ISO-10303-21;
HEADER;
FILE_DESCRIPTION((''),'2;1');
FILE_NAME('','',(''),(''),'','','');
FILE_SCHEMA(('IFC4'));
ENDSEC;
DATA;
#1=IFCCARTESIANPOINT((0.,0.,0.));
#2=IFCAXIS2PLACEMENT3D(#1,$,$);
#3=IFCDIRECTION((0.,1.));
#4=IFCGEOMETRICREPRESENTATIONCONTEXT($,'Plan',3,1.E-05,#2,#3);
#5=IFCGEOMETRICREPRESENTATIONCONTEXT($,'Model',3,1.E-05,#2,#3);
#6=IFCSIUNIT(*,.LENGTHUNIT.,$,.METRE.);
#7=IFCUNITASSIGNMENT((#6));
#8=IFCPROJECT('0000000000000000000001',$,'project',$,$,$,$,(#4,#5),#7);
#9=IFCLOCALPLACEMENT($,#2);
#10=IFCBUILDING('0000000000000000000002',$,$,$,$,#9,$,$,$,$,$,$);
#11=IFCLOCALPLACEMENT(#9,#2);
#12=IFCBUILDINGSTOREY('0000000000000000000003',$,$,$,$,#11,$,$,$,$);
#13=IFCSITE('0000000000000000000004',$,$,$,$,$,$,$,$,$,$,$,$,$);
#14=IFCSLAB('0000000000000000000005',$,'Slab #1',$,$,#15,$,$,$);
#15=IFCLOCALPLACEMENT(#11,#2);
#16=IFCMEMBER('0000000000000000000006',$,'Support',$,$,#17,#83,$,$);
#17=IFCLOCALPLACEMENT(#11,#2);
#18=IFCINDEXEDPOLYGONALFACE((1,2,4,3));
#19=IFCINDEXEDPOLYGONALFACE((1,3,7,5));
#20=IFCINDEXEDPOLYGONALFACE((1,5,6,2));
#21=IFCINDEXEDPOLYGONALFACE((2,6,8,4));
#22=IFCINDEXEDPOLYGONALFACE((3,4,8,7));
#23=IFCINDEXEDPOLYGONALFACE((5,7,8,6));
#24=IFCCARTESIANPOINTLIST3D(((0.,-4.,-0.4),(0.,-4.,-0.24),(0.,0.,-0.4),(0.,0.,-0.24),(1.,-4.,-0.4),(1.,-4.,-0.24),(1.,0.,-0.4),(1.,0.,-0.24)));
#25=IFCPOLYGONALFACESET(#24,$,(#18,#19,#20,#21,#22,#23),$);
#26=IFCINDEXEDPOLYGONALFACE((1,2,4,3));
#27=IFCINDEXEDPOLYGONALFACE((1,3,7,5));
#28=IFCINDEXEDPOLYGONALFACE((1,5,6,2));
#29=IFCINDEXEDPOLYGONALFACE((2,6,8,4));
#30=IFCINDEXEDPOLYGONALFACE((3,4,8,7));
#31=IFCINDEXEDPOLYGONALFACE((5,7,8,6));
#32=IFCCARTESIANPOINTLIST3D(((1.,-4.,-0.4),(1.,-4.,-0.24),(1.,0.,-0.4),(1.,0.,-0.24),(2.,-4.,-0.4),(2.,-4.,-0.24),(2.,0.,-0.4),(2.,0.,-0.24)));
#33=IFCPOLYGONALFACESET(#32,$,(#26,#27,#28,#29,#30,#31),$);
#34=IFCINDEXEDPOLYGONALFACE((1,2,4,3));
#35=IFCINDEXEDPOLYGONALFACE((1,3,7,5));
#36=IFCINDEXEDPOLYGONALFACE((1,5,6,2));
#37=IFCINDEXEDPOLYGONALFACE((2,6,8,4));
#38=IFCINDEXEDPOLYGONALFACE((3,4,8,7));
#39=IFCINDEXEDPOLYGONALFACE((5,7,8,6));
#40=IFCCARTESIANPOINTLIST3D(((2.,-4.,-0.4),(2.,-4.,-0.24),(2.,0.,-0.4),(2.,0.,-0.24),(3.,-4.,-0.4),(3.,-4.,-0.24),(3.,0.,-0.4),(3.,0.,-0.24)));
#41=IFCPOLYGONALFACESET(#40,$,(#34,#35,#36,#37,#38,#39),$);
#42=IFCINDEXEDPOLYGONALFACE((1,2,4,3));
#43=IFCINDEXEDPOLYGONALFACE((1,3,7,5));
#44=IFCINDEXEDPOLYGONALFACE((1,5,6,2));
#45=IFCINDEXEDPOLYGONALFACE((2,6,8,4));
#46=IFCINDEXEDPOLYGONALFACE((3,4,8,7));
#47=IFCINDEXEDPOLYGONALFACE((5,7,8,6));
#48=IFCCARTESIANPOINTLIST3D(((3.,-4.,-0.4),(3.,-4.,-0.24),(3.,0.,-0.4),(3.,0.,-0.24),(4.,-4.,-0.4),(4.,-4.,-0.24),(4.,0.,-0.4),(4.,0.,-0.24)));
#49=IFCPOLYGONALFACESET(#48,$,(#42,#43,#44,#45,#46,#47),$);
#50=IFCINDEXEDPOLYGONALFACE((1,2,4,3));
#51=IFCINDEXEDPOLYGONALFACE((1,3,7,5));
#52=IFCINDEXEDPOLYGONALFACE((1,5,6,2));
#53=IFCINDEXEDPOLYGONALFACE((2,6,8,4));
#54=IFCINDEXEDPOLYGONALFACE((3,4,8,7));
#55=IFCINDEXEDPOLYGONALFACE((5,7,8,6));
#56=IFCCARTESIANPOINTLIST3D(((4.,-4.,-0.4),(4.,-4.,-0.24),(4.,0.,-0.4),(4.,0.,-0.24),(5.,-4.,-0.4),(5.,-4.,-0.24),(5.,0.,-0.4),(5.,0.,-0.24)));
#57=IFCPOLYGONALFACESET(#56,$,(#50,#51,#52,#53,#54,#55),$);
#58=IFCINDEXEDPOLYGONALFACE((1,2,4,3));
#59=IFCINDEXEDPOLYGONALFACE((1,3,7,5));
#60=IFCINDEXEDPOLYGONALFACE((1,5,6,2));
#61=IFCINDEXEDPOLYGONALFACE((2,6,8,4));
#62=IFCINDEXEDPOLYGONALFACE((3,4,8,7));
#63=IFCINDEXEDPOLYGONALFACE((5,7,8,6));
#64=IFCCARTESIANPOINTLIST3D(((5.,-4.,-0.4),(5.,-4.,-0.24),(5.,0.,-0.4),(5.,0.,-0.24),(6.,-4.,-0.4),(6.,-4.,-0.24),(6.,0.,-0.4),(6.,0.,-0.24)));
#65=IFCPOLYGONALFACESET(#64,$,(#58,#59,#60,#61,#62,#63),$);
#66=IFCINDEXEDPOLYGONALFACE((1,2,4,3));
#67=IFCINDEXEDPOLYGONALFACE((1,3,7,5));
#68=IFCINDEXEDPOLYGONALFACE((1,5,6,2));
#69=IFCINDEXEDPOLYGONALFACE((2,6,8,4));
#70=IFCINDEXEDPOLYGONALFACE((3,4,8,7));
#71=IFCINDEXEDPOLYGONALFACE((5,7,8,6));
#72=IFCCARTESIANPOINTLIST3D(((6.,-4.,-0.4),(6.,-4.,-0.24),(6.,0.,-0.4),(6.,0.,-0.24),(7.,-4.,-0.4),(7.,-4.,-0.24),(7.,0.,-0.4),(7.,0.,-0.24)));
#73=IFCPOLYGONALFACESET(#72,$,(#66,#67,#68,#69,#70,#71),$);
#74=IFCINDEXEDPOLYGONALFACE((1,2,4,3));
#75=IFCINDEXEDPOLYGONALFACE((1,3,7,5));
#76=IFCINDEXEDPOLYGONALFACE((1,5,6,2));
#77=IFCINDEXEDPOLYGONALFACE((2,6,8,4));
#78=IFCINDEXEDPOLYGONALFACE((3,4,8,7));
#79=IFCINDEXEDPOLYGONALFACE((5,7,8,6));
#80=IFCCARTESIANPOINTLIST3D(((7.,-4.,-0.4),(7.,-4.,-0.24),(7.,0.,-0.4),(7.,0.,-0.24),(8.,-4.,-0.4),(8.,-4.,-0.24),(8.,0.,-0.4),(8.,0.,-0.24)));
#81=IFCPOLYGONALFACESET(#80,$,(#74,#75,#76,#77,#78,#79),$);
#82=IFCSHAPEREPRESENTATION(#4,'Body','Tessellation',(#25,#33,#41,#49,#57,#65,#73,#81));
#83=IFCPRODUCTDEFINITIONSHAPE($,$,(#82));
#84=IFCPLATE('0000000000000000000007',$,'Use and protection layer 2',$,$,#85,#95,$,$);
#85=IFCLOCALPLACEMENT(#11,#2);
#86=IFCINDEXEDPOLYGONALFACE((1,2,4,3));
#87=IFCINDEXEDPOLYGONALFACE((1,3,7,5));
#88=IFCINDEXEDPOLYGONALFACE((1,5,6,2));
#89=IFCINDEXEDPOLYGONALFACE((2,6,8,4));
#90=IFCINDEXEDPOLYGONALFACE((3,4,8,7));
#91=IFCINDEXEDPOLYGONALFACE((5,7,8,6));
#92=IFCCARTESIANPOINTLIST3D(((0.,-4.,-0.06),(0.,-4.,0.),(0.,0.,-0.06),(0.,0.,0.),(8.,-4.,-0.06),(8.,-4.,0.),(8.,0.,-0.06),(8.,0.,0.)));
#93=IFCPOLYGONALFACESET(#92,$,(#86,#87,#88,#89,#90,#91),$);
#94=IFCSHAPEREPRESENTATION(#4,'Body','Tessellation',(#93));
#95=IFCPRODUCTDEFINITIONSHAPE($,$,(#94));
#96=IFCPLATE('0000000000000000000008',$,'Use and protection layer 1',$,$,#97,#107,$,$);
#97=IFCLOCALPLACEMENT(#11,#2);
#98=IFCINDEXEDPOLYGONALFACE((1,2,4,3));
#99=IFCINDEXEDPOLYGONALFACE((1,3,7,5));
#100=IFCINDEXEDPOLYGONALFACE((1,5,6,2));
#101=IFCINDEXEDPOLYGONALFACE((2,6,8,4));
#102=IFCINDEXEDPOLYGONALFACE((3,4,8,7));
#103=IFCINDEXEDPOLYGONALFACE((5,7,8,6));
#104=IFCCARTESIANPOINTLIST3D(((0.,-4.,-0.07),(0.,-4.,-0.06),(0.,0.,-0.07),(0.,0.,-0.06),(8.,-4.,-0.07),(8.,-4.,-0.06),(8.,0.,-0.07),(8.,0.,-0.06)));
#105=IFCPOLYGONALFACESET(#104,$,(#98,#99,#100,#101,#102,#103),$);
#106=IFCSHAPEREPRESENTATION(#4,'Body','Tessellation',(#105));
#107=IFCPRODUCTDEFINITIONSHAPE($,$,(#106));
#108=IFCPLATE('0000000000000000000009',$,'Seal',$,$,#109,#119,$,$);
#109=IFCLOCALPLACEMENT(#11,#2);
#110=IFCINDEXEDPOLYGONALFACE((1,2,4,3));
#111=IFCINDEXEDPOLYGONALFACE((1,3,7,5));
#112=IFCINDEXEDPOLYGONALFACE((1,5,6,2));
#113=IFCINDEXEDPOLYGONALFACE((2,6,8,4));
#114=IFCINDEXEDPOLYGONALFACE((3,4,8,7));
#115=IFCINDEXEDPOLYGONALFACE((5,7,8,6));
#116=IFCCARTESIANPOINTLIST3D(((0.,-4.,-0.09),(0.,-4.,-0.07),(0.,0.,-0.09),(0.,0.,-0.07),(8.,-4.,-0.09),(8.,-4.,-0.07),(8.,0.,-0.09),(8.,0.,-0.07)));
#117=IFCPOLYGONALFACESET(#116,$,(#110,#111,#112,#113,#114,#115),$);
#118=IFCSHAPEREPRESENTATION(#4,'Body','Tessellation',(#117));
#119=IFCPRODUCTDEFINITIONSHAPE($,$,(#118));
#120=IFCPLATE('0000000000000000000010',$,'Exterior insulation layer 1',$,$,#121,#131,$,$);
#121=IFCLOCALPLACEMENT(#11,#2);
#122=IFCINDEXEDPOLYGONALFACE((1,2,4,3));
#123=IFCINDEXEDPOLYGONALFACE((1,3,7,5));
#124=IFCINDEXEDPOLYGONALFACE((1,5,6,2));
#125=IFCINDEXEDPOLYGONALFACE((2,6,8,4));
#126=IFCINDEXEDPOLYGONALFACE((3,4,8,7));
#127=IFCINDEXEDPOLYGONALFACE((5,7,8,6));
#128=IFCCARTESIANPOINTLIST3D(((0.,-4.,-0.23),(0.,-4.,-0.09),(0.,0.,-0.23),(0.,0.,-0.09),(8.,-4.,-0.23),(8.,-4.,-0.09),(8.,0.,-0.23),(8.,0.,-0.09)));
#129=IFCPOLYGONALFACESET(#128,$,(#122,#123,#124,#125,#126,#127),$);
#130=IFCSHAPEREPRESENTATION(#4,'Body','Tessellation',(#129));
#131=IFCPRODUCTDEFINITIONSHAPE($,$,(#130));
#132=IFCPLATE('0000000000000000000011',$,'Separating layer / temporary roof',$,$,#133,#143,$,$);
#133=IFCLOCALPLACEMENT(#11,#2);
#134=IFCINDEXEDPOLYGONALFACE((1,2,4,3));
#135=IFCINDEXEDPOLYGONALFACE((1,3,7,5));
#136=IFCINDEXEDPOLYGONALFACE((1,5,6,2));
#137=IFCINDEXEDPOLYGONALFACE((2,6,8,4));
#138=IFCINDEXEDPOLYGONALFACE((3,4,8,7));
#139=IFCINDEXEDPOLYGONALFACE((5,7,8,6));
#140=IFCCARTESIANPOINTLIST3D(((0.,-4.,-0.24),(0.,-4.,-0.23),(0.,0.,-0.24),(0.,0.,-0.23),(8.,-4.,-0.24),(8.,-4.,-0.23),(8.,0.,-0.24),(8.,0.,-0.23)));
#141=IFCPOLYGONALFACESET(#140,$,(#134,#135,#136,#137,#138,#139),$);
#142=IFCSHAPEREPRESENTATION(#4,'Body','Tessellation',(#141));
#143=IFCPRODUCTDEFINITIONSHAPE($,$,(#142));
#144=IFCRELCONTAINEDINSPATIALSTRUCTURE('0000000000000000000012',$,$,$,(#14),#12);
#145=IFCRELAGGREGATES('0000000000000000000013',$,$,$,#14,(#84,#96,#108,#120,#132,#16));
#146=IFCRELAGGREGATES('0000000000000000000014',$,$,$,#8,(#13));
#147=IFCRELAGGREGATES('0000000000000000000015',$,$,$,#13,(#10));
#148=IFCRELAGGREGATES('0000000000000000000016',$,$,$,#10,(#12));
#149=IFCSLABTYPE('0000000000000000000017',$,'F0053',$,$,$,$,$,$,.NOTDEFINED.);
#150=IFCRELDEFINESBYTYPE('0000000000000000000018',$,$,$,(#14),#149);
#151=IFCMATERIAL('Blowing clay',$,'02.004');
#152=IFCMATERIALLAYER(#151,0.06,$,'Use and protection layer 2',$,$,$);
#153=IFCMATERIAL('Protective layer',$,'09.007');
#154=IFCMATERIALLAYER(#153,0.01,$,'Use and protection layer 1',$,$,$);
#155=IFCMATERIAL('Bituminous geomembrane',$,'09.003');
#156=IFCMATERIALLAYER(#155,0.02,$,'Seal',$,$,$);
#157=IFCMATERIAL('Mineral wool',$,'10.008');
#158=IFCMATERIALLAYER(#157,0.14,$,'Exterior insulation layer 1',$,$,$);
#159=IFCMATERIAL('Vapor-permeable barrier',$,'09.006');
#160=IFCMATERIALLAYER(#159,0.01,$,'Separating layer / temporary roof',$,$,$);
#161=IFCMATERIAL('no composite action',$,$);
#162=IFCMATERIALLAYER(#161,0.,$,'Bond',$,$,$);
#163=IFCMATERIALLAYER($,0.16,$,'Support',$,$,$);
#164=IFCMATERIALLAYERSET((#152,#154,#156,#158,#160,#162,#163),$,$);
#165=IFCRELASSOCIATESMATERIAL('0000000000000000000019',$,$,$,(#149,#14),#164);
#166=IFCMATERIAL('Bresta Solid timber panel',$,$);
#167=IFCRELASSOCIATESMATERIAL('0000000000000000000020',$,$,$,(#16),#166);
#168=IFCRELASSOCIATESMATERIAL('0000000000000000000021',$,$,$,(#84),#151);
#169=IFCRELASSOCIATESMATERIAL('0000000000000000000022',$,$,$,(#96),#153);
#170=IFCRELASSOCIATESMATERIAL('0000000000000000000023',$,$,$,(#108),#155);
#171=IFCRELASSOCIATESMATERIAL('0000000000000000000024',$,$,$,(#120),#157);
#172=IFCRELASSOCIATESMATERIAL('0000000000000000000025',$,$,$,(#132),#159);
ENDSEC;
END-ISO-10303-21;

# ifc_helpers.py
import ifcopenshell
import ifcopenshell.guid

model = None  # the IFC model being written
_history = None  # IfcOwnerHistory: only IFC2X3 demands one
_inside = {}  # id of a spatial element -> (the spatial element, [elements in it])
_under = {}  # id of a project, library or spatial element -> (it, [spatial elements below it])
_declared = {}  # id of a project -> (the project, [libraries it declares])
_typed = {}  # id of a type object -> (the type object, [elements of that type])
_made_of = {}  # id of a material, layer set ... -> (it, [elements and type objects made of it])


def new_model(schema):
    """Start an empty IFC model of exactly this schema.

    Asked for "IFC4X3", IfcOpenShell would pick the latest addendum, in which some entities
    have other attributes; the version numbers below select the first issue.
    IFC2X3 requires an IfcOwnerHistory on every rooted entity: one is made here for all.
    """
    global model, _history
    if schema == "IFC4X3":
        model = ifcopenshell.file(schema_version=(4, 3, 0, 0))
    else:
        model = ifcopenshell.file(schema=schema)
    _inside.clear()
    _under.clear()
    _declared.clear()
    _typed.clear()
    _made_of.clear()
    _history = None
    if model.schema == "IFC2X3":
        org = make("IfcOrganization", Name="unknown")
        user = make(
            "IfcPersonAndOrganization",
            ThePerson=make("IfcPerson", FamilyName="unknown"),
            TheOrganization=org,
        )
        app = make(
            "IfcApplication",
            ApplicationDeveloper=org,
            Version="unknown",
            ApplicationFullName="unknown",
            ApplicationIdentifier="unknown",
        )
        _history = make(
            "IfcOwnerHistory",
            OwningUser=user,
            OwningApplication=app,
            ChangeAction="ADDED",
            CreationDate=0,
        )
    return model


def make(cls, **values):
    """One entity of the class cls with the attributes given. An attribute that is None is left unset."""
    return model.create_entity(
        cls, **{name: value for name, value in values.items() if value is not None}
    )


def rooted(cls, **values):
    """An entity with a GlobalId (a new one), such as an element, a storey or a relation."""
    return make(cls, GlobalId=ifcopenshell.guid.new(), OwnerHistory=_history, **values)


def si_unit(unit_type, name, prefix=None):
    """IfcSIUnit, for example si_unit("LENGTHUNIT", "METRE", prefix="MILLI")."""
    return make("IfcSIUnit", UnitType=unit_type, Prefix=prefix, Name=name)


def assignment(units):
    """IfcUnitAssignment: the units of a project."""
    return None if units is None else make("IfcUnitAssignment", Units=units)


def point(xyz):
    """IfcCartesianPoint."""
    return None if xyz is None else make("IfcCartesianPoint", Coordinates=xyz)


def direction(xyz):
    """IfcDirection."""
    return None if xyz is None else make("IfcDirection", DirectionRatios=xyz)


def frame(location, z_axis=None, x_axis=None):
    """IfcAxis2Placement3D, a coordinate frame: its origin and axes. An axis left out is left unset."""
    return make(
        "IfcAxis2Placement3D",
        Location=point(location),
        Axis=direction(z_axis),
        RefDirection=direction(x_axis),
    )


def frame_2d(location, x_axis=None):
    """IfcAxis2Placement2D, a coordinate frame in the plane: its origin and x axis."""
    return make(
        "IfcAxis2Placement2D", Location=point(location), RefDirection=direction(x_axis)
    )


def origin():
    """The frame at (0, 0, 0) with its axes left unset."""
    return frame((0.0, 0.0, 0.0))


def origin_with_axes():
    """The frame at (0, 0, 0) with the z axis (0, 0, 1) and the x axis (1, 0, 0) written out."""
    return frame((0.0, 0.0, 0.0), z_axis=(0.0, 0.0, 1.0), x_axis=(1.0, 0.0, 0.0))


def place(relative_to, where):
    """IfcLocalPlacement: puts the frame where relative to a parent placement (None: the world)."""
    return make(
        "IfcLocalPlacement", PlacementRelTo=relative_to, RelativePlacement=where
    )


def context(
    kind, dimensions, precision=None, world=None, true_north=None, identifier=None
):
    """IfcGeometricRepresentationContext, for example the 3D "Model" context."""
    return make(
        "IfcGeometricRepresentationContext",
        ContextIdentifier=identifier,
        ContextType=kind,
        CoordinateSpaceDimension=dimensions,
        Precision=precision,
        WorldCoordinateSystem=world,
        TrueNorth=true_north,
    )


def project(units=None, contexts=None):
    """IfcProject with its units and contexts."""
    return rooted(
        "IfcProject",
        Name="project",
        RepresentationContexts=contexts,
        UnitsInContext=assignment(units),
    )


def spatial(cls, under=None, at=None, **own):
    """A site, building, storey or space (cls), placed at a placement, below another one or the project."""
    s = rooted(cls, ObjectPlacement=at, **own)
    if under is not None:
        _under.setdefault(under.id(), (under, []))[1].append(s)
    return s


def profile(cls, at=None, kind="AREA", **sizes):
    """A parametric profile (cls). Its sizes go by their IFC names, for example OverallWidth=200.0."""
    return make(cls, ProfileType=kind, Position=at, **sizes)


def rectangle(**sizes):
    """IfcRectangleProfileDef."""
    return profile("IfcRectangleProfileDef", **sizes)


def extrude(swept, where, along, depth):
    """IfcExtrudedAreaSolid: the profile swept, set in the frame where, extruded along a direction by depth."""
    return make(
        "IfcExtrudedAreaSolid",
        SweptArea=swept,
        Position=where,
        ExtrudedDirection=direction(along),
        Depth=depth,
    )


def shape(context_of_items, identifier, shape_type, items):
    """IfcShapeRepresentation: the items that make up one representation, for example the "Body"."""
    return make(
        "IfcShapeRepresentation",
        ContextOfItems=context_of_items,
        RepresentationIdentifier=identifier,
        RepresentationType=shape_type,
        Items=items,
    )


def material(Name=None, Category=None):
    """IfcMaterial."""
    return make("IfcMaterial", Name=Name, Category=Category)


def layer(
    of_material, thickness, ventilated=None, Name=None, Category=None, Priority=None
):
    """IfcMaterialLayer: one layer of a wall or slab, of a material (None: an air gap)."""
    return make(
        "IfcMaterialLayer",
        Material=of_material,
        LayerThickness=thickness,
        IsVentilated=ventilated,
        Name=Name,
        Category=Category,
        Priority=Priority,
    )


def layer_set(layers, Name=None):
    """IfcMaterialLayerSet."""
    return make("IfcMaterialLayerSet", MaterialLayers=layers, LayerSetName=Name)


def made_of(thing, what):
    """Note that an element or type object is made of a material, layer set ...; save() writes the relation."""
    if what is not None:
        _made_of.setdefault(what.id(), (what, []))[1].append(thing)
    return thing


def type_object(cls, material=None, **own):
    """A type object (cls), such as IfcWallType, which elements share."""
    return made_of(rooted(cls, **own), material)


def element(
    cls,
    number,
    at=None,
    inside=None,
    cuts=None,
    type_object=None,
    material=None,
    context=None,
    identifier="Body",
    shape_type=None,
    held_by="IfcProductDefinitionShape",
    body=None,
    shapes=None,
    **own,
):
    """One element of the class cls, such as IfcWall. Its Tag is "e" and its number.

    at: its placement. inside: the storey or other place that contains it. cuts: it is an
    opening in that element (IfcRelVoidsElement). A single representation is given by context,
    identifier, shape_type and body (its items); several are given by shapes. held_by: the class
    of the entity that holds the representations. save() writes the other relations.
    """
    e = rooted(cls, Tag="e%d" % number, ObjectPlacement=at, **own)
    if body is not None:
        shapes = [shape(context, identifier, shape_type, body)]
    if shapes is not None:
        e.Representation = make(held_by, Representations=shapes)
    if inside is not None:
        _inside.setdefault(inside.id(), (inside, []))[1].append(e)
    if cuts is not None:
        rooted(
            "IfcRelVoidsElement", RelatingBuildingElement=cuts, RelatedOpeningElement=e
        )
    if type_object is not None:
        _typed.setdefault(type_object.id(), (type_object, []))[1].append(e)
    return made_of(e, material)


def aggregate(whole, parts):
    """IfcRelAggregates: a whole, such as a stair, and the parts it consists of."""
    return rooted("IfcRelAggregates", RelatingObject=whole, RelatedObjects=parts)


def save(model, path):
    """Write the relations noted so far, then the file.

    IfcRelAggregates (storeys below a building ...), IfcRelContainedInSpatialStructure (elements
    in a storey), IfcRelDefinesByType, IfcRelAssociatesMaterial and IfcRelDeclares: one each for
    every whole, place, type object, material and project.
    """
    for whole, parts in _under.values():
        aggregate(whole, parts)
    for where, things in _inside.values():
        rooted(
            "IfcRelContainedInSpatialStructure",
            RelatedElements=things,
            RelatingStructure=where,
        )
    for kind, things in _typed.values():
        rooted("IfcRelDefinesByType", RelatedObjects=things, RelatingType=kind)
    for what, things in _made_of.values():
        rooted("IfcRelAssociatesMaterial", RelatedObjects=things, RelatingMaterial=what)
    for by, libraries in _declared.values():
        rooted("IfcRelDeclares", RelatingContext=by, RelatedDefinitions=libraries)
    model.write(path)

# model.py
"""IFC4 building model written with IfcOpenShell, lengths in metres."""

from ifc_helpers import new_model, si_unit, direction, frame, frame_2d, origin, origin_with_axes, place, context, project, spatial, rectangle, extrude, material, layer, layer_set, type_object, element, aggregate, save


model = new_model("IFC4")

# Units and contexts
plan_context = context("Plan", 3, precision=1e-05, world=origin(), true_north=direction((0.0, 1.0)))
model_context = context("Model", 3, precision=1e-05, world=origin(), true_north=direction((0.0, 1.0)))
ifc_project = project(units=[si_unit("LENGTHUNIT", "METRE")], contexts=[plan_context, model_context])

# Site, building, storey
site = spatial("IfcSite", under=ifc_project)
building_placement = place(None, origin())
building = spatial("IfcBuilding", under=site, at=building_placement)
storey_placement = place(building_placement, origin())
storey = spatial("IfcBuildingStorey", under=building, at=storey_placement)

# Slab, member, plates
ifc_material_1 = material(Name="Blowing clay", Category="02.004")
ifc_layer_1 = layer(ifc_material_1, 0.06, Name="Use and protection layer 2")
ifc_material_2 = material(Name="Protective layer", Category="09.007")
ifc_layer_2 = layer(ifc_material_2, 0.01, Name="Use and protection layer 1")
ifc_material_3 = material(Name="Bituminous geomembrane", Category="09.003")
ifc_layer_3 = layer(ifc_material_3, 0.02, Name="Seal")
ifc_material_4 = material(Name="Mineral wool", Category="10.008")
ifc_layer_4 = layer(ifc_material_4, 0.14, Name="Exterior insulation layer 1")
ifc_material_5 = material(Name="Vapor-permeable barrier", Category="09.006")
ifc_layer_5 = layer(ifc_material_5, 0.01, Name="Separating layer / temporary roof")
ifc_material_6 = material(Name="no composite action")
ifc_layer_6 = layer(ifc_material_6, 0.0, Name="Bond")
ifc_layer_7 = layer(None, 0.16, Name="Support")
ifc_layer_set = layer_set([ifc_layer_1, ifc_layer_2, ifc_layer_3, ifc_layer_4, ifc_layer_5, ifc_layer_6, ifc_layer_7])
slab_type = type_object("IfcSlabType", Name="F0053", PredefinedType="NOTDEFINED", material=ifc_layer_set)
slab_placement = place(None, frame((0.0, 0.0, 0.0), z_axis=(0.0, 0.0, -1.0), x_axis=(1.0, 0.0, 0.0)))
slab = element("IfcSlab", 1, at=slab_placement, inside=storey, type_object=slab_type, material=ifc_layer_set, Name="Slab #1")
ifc_material_7 = material(Name="Bresta Solid timber panel")
member_placement = place(slab_placement, origin())
member = element("IfcMember", 2, at=member_placement, material=ifc_material_7, Name="Support", context=plan_context, shape_type="SweptSolid", body=[
    extrude(rectangle(XDim=1.0, YDim=0.16, at=frame_2d((0.5, 0.08), x_axis=(1.0, 0.0))), frame((0.0, 4.0, 0.24), z_axis=(0.0, -1.0, 0.0), x_axis=(1.0, 0.0, 0.0)), (0.0, 0.0, 1.0), 4.0),
    extrude(rectangle(XDim=1.0, YDim=0.16, at=frame_2d((0.5, 0.08), x_axis=(1.0, 0.0))), frame((1.0, 4.0, 0.24), z_axis=(0.0, -1.0, 0.0), x_axis=(1.0, 0.0, 0.0)), (0.0, 0.0, 1.0), 4.0),
    extrude(rectangle(XDim=1.0, YDim=0.16, at=frame_2d((0.5, 0.08), x_axis=(1.0, 0.0))), frame((2.0, 4.0, 0.24), z_axis=(0.0, -1.0, 0.0), x_axis=(1.0, 0.0, 0.0)), (0.0, 0.0, 1.0), 4.0),
    extrude(rectangle(XDim=1.0, YDim=0.16, at=frame_2d((0.5, 0.08), x_axis=(1.0, 0.0))), frame((3.0, 4.0, 0.24), z_axis=(0.0, -1.0, 0.0), x_axis=(1.0, 0.0, 0.0)), (0.0, 0.0, 1.0), 4.0),
    extrude(rectangle(XDim=1.0, YDim=0.16, at=frame_2d((0.5, 0.08), x_axis=(1.0, 0.0))), frame((4.0, 4.0, 0.24), z_axis=(0.0, -1.0, 0.0), x_axis=(1.0, 0.0, 0.0)), (0.0, 0.0, 1.0), 4.0),
    extrude(rectangle(XDim=1.0, YDim=0.16, at=frame_2d((0.5, 0.08), x_axis=(1.0, 0.0))), frame((5.0, 4.0, 0.24), z_axis=(0.0, -1.0, 0.0), x_axis=(1.0, 0.0, 0.0)), (0.0, 0.0, 1.0), 4.0),
    extrude(rectangle(XDim=1.0, YDim=0.16, at=frame_2d((0.5, 0.08), x_axis=(1.0, 0.0))), frame((6.0, 4.0, 0.24), z_axis=(0.0, -1.0, 0.0), x_axis=(1.0, 0.0, 0.0)), (0.0, 0.0, 1.0), 4.0),
    extrude(rectangle(XDim=1.0, YDim=0.16, at=frame_2d((0.5, 0.08), x_axis=(1.0, 0.0))), frame((7.0, 4.0, 0.24), z_axis=(0.0, -1.0, 0.0), x_axis=(1.0, 0.0, 0.0)), (0.0, 0.0, 1.0), 4.0),
])
plate_1_placement = place(slab_placement, origin())
plate_1 = element("IfcPlate", 3, at=plate_1_placement, material=ifc_material_1, Name="Use and protection layer 2", context=plan_context, shape_type="SweptSolid", body=[
    extrude(rectangle(XDim=8.0, YDim=4.0, at=frame_2d((4.0, 2.0), x_axis=(1.0, 0.0))), origin_with_axes(), (0.0, 0.0, 1.0), 0.06),
])
plate_2_placement = place(slab_placement, origin())
plate_2 = element("IfcPlate", 4, at=plate_2_placement, material=ifc_material_2, Name="Use and protection layer 1", context=plan_context, shape_type="SweptSolid", body=[
    extrude(rectangle(XDim=8.0, YDim=4.0, at=frame_2d((4.0, 2.0), x_axis=(1.0, 0.0))), frame((0.0, 0.0, 0.06), z_axis=(0.0, 0.0, 1.0), x_axis=(1.0, 0.0, 0.0)), (0.0, 0.0, 1.0), 0.01),
])
plate_3_placement = place(slab_placement, origin())
plate_3 = element("IfcPlate", 5, at=plate_3_placement, material=ifc_material_3, Name="Seal", context=plan_context, shape_type="SweptSolid", body=[
    extrude(rectangle(XDim=8.0, YDim=4.0, at=frame_2d((4.0, 2.0), x_axis=(1.0, 0.0))), frame((0.0, 0.0, 0.07), z_axis=(0.0, 0.0, 1.0), x_axis=(1.0, 0.0, 0.0)), (0.0, 0.0, 1.0), 0.02),
])
plate_4_placement = place(slab_placement, origin())
plate_4 = element("IfcPlate", 6, at=plate_4_placement, material=ifc_material_4, Name="Exterior insulation layer 1", context=plan_context, shape_type="SweptSolid", body=[
    extrude(rectangle(XDim=8.0, YDim=4.0, at=frame_2d((4.0, 2.0), x_axis=(1.0, 0.0))), frame((0.0, 0.0, 0.09), z_axis=(0.0, 0.0, 1.0), x_axis=(1.0, 0.0, 0.0)), (0.0, 0.0, 1.0), 0.14),
])
plate_5_placement = place(slab_placement, origin())
plate_5 = element("IfcPlate", 7, at=plate_5_placement, material=ifc_material_5, Name="Separating layer / temporary roof", context=plan_context, shape_type="SweptSolid", body=[
    extrude(rectangle(XDim=8.0, YDim=4.0, at=frame_2d((4.0, 2.0), x_axis=(1.0, 0.0))), frame((0.0, 0.0, 0.23), z_axis=(0.0, 0.0, 1.0), x_axis=(1.0, 0.0, 0.0)), (0.0, 0.0, 1.0), 0.01),
])
aggregate(slab, [plate_1, plate_2, plate_3, plate_4, plate_5, member])

save(model, "model.ifc")
